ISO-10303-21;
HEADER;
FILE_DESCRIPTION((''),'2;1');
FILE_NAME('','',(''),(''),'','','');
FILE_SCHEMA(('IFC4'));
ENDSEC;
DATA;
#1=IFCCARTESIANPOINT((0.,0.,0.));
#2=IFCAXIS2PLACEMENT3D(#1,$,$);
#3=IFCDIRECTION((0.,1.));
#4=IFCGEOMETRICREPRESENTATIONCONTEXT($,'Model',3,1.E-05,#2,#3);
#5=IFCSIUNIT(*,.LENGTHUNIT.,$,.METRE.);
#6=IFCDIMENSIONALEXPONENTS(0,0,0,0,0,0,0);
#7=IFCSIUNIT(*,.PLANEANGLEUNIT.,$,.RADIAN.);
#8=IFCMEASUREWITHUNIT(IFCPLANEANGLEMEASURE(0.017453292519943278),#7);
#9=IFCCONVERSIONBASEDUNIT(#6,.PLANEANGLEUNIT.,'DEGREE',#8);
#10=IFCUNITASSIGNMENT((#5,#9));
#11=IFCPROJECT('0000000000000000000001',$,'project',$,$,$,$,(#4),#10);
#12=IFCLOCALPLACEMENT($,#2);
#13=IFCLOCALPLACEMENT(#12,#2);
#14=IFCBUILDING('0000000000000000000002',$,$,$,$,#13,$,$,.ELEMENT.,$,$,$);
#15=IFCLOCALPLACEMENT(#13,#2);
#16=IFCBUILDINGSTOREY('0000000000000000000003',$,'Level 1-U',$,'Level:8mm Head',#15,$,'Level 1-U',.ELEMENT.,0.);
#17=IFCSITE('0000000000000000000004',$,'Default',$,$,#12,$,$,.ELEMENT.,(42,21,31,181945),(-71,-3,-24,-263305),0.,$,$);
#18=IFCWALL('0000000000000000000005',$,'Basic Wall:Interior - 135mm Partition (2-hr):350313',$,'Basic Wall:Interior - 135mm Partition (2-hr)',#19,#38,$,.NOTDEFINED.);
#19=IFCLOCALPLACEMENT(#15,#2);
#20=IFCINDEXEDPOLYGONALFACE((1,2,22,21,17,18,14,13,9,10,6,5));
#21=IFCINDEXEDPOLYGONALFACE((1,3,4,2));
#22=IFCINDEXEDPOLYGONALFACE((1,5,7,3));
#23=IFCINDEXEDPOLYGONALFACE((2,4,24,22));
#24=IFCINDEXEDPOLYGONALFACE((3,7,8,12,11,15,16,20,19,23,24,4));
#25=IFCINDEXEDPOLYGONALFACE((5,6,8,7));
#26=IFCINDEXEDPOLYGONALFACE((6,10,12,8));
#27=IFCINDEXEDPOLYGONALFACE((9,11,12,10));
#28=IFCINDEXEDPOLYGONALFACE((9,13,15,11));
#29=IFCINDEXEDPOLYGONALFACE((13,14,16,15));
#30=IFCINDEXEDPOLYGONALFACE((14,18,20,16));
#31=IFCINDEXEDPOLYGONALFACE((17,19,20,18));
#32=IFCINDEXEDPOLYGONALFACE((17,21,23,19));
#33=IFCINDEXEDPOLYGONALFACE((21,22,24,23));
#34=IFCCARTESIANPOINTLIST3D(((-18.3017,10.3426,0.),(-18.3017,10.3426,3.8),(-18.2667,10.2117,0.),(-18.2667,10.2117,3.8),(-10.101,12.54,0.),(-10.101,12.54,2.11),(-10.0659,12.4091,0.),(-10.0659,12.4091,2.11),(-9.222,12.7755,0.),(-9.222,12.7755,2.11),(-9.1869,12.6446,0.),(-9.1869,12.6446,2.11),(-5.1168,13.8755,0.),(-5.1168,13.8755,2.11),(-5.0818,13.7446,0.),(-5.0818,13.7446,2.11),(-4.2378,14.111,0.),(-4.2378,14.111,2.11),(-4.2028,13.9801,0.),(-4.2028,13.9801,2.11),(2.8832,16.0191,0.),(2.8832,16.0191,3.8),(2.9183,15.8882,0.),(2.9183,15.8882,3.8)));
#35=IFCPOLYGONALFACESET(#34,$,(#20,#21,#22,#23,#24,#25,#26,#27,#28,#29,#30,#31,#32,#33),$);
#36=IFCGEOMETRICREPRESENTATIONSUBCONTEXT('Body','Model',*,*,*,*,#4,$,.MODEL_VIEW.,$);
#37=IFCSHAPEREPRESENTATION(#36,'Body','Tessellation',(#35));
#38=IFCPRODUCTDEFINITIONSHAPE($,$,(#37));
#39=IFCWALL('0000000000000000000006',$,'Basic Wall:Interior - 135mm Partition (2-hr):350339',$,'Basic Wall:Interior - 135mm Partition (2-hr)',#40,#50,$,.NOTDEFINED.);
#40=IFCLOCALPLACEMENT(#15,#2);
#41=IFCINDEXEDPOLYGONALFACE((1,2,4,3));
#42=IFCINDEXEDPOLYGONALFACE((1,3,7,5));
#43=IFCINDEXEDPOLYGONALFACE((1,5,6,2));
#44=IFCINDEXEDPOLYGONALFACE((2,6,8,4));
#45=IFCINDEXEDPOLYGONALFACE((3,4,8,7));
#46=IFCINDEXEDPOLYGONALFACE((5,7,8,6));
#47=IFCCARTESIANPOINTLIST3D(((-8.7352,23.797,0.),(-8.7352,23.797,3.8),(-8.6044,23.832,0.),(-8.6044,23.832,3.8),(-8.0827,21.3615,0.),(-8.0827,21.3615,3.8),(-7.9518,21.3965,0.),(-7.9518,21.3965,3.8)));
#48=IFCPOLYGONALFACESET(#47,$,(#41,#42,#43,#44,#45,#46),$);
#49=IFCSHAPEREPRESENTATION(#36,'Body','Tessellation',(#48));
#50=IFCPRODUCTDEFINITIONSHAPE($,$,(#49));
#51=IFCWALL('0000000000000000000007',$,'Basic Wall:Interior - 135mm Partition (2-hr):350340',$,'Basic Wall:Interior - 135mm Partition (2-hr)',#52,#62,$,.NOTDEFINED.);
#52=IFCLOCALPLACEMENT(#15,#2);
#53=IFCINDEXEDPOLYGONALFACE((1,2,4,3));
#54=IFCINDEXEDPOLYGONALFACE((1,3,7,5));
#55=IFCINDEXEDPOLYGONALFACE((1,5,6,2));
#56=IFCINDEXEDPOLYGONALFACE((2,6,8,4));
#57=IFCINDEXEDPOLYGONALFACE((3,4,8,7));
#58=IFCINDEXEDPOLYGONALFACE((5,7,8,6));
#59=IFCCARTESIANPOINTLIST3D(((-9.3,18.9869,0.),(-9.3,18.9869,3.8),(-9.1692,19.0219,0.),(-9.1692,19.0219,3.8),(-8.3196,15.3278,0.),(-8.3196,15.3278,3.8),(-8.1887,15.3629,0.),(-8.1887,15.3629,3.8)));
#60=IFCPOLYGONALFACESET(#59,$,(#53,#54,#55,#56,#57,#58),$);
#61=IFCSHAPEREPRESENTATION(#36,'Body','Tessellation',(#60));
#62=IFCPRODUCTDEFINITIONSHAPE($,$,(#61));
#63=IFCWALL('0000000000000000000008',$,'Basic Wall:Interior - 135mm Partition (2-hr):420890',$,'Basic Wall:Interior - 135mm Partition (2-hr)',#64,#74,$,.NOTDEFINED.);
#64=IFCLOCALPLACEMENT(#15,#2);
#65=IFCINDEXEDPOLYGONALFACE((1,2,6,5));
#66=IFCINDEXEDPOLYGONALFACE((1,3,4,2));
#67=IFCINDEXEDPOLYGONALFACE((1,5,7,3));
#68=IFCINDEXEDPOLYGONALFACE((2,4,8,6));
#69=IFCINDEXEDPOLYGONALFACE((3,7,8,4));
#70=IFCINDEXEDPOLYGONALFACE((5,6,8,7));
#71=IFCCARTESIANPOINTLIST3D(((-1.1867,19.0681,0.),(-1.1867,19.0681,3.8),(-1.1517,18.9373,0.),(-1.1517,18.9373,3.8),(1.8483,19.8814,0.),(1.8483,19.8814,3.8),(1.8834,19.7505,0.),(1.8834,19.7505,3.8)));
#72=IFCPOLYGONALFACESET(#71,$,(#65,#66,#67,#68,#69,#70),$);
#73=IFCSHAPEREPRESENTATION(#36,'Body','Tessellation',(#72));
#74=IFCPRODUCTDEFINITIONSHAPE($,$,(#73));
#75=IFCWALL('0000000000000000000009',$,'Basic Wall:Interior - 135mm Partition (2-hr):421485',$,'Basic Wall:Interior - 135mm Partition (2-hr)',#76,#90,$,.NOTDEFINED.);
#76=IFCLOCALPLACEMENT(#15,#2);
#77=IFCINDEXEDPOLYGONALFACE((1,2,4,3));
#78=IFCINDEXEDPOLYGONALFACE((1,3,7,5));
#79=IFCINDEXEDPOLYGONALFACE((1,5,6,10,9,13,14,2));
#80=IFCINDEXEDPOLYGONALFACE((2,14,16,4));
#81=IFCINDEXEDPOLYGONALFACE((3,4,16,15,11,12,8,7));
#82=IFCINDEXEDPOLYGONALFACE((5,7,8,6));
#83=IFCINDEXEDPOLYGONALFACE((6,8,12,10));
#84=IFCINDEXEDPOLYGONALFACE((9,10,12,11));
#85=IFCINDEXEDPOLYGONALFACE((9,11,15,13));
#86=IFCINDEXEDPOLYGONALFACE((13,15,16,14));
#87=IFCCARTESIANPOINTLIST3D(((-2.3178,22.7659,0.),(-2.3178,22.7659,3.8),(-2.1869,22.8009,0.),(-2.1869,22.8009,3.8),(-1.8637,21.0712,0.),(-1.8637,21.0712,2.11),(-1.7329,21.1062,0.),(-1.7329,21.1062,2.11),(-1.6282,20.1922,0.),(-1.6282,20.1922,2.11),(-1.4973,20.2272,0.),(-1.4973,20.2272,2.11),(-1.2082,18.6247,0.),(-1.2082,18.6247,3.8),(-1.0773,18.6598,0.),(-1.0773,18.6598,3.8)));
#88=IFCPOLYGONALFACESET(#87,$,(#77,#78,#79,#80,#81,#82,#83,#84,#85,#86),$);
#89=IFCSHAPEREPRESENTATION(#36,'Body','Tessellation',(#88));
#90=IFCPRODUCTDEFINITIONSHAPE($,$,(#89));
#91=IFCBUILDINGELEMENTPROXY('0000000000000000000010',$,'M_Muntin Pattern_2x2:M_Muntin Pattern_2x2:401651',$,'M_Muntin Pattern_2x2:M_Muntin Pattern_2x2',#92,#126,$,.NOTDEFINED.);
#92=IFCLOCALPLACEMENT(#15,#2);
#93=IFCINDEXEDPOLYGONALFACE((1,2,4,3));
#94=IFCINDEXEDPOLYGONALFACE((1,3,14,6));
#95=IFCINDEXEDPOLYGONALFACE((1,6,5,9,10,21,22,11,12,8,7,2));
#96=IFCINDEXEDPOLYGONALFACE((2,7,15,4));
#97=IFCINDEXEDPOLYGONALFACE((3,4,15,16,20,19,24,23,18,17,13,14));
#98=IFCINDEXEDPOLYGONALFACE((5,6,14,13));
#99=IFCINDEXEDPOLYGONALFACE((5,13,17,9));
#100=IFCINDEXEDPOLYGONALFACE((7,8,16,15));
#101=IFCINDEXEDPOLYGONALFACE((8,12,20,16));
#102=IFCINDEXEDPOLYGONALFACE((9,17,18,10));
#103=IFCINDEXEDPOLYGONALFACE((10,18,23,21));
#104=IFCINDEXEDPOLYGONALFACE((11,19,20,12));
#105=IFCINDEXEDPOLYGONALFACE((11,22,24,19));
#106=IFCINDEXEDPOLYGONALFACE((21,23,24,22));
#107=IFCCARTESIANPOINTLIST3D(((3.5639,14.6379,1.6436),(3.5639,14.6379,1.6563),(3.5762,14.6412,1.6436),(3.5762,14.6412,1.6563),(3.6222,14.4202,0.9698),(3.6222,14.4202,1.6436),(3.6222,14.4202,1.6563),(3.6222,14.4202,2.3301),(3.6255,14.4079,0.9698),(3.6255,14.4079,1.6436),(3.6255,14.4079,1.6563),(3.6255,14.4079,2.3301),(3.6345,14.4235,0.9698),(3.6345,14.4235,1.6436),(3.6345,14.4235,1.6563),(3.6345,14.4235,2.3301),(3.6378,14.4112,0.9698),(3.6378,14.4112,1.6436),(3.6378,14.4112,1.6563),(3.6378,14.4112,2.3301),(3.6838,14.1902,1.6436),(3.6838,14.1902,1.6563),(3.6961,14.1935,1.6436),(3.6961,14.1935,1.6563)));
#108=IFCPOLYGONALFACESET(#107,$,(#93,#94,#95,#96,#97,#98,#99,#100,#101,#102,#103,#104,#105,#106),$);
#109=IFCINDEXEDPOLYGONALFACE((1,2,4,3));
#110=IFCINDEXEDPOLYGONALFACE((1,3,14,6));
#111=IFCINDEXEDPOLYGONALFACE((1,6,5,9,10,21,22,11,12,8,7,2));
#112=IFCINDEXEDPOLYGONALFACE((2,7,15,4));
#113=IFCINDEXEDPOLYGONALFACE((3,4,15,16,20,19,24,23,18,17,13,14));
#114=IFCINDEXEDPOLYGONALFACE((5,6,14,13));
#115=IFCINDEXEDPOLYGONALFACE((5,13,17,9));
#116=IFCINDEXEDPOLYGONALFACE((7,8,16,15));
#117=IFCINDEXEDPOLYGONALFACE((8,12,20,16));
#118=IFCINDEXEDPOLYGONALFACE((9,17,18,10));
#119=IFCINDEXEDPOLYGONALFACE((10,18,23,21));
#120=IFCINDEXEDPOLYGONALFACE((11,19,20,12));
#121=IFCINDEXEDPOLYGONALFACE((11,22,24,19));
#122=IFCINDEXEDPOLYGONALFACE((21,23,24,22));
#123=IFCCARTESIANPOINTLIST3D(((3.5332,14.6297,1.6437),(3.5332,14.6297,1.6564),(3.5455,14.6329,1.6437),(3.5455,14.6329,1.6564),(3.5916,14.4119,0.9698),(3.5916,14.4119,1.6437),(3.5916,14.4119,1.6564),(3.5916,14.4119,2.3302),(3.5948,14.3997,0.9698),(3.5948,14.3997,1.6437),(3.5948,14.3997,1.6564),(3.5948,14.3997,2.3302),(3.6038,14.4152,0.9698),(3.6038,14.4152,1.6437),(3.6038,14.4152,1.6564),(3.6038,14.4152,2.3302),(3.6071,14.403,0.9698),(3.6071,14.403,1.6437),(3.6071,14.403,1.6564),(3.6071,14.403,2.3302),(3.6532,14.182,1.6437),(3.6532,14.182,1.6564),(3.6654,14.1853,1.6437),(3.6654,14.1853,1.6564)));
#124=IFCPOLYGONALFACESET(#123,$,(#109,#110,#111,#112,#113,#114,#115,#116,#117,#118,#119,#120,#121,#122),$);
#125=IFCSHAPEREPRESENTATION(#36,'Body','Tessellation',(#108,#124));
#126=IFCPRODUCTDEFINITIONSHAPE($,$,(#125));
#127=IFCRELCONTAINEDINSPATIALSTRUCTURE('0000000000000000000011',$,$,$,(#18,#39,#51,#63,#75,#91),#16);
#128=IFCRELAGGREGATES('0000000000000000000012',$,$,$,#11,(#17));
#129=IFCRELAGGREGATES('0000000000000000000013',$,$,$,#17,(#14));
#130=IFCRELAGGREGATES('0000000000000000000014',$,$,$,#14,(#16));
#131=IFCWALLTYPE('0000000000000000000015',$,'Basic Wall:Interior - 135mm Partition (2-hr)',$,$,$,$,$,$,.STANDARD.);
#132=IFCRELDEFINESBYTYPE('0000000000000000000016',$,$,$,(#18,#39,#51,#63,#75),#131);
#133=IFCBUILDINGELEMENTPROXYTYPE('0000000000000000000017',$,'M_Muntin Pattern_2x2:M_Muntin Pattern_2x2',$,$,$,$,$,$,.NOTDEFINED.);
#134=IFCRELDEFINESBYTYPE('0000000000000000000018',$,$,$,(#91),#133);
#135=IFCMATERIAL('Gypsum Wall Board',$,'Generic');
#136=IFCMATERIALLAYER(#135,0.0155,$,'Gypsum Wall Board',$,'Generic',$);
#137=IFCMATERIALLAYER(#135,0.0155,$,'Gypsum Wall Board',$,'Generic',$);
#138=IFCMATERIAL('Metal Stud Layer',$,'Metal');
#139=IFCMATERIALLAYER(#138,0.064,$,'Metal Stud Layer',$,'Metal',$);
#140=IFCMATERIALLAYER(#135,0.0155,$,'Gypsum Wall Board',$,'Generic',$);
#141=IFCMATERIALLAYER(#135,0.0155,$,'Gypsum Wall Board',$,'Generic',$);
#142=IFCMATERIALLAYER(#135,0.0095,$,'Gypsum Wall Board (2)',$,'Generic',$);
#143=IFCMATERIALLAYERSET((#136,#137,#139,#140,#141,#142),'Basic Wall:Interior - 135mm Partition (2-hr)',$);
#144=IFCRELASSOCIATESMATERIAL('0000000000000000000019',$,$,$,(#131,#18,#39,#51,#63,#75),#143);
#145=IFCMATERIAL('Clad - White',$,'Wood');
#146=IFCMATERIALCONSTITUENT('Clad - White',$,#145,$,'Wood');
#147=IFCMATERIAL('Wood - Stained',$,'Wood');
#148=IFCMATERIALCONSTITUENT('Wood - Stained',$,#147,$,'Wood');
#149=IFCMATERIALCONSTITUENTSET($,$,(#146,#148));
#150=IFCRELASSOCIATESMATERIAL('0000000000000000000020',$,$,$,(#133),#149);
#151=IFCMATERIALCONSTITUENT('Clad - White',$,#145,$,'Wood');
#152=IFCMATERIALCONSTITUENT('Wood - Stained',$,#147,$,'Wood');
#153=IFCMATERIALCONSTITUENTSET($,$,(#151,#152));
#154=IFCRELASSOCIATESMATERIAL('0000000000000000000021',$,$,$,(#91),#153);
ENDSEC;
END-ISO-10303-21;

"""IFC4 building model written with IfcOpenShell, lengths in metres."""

from ifc_helpers import new_model, entity, si_unit, converted_unit, direction, frame, frame_2d, origin, place, context, subcontext, project, spatial, polyline, rectangle, outline, extrude, source, transform, mapped, material, layer, layer_set, layer_usage, constituent, constituent_set, type_object, type_shapes, element, save


model = new_model("IFC4")

# Units and contexts
model_context = context("Model", 3, precision=1e-05, world=origin(), true_north=direction((0.0, 1.0)))
body_context = subcontext(model_context, "Body", "Model", "MODEL_VIEW")
ifc_project = project(units=[si_unit("LENGTHUNIT", "METRE"), converted_unit("PLANEANGLEUNIT", "DEGREE", entity("IfcPlaneAngleMeasure", 0.017453292519943278), si_unit("PLANEANGLEUNIT", "RADIAN"), dimensions=[0, 0, 0, 0, 0, 0, 0])], contexts=[model_context])

# Site, building, storey
site_placement = place(None, origin())
site = spatial("IfcSite", under=ifc_project, at=site_placement, Name="Default", CompositionType="ELEMENT", RefLatitude=(42, 21, 31, 181945), RefLongitude=(-71, -3, -24, -263305), RefElevation=0.0)
building_placement = place(site_placement, origin())
building = spatial("IfcBuilding", under=site, at=building_placement, CompositionType="ELEMENT")
storey_placement = place(building_placement, origin())
storey = spatial("IfcBuildingStorey", under=building, at=storey_placement, Name="Level 1-U", ObjectType="Level:8mm Head", LongName="Level 1-U", CompositionType="ELEMENT", Elevation=0.0)

# Shared definitions
ifc_material_1 = material(Name="Gypsum Wall Board", Category="Generic")
ifc_layer_1 = layer(ifc_material_1, 0.0155, Name="Gypsum Wall Board", Category="Generic")
ifc_layer_2 = layer(ifc_material_1, 0.0155, Name="Gypsum Wall Board", Category="Generic")
ifc_material_2 = material(Name="Metal Stud Layer", Category="Metal")
ifc_layer_3 = layer(ifc_material_2, 0.064, Name="Metal Stud Layer", Category="Metal")
ifc_layer_4 = layer(ifc_material_1, 0.0155, Name="Gypsum Wall Board", Category="Generic")
ifc_layer_5 = layer(ifc_material_1, 0.0155, Name="Gypsum Wall Board", Category="Generic")
ifc_layer_6 = layer(ifc_material_1, 0.0095, Name="Gypsum Wall Board (2)", Category="Generic")
ifc_layer_set_1 = layer_set([ifc_layer_1, ifc_layer_2, ifc_layer_3, ifc_layer_4, ifc_layer_5, ifc_layer_6], Name="Basic Wall:Interior - 135mm Partition (2-hr)")
ifc_layer_usage_1 = layer_usage(ifc_layer_set_1, "AXIS2", "NEGATIVE", 0.0677)
wall_type_1 = type_object("IfcWallType", Name="Basic Wall:Interior - 135mm Partition (2-hr)", PredefinedType="STANDARD", material=ifc_layer_set_1)

# Wall, openings
wall_1_placement = place(storey_placement, frame((2.9007, 15.9537, 0.0), z_axis=(0.0, 0.0, 1.0), x_axis=(-0.965926, -0.258819, 0.0)))
wall_1 = element("IfcWall", 1, at=wall_1_placement, inside=storey, type_object=wall_type_1, material=ifc_layer_usage_1, Name="Basic Wall:Interior - 135mm Partition (2-hr):350313", ObjectType="Basic Wall:Interior - 135mm Partition (2-hr)", PredefinedType="NOTDEFINED", context=body_context, shape_type="SweptSolid", body=[
    extrude(rectangle(XDim=21.9323, YDim=0.1355, at=frame_2d((10.9661, 0.0), x_axis=(1.0, 0.0))), origin(), (0.0, 0.0, 1.0), 3.8),
])
opening_1_placement = place(wall_1_placement, frame((7.3722, -0.0678, 0.0)))
element("IfcOpeningElement", 2, at=opening_1_placement, cuts=wall_1, PredefinedType="OPENING", context=body_context, shape_type="SweptSolid", body=[
    extrude(rectangle(XDim=2.11, YDim=0.91, at=frame_2d((1.055, 0.455), x_axis=(1.0, 0.0))), frame((0.0, 0.0, 0.0), z_axis=(0.0, 1.0, 0.0), x_axis=(0.0, 0.0, 1.0)), (0.0, 0.0, 1.0), 0.1355),
])
opening_2_placement = place(wall_1_placement, frame((12.5323, -0.0678, 0.0)))
element("IfcOpeningElement", 3, at=opening_2_placement, cuts=wall_1, PredefinedType="OPENING", context=body_context, shape_type="SweptSolid", body=[
    extrude(rectangle(XDim=2.11, YDim=0.91, at=frame_2d((1.055, 0.455), x_axis=(1.0, 0.0))), frame((0.0, 0.0, 0.0), z_axis=(0.0, 1.0, 0.0), x_axis=(0.0, 0.0, 1.0)), (0.0, 0.0, 1.0), 0.1355),
])

# Walls
wall_2_placement = place(storey_placement, frame((-8.0172, 21.379, 0.0), z_axis=(0.0, 0.0, 1.0), x_axis=(-0.258819, 0.965926, 0.0)))
element("IfcWall", 4, at=wall_2_placement, inside=storey, type_object=wall_type_1, material=ifc_layer_usage_1, Name="Basic Wall:Interior - 135mm Partition (2-hr):350339", ObjectType="Basic Wall:Interior - 135mm Partition (2-hr)", PredefinedType="NOTDEFINED", context=body_context, shape_type="SweptSolid", body=[
    extrude(rectangle(XDim=2.5214, YDim=0.1355, at=frame_2d((1.2607, 0.0), x_axis=(-1.0, 0.0))), origin(), (0.0, 0.0, 1.0), 3.8),
])
wall_3_placement = place(storey_placement, frame((-8.2542, 15.3453, 0.0), z_axis=(0.0, 0.0, 1.0), x_axis=(-0.258819, 0.965926, 0.0)))
element("IfcWall", 5, at=wall_3_placement, inside=storey, type_object=wall_type_1, material=ifc_layer_usage_1, Name="Basic Wall:Interior - 135mm Partition (2-hr):350340", ObjectType="Basic Wall:Interior - 135mm Partition (2-hr)", PredefinedType="NOTDEFINED", context=body_context, shape_type="SweptSolid", body=[
    extrude(rectangle(XDim=3.7881, YDim=0.1355, at=frame_2d((1.8941, 0.0), x_axis=(-1.0, 0.0))), origin(), (0.0, 0.0, 1.0), 3.8),
])
wall_4_placement = place(storey_placement, frame((-1.1692, 19.0027, 0.0), z_axis=(0.0, 0.0, 1.0), x_axis=(0.965926, 0.258819, 0.0)))
element("IfcWall", 6, at=wall_4_placement, inside=storey, type_object=wall_type_1, material=ifc_layer_usage_1, Name="Basic Wall:Interior - 135mm Partition (2-hr):420890", ObjectType="Basic Wall:Interior - 135mm Partition (2-hr)", PredefinedType="NOTDEFINED", context=body_context, shape_type="SweptSolid", body=[
    extrude(rectangle(XDim=3.1421, YDim=0.1355, at=frame_2d((1.5711, 0.0), x_axis=(-1.0, 0.0))), origin(), (0.0, 0.0, 1.0), 3.8),
])

# Wall, opening
wall_5_placement = place(storey_placement, frame((-1.1428, 18.6422, 0.0), z_axis=(0.0, 0.0, 1.0), x_axis=(-0.258819, 0.965926, 0.0)))
wall_5 = element("IfcWall", 7, at=wall_5_placement, inside=storey, type_object=wall_type_1, material=ifc_layer_usage_1, Name="Basic Wall:Interior - 135mm Partition (2-hr):421485", ObjectType="Basic Wall:Interior - 135mm Partition (2-hr)", PredefinedType="NOTDEFINED", context=body_context, shape_type="SweptSolid", body=[
    extrude(rectangle(XDim=4.2873, YDim=0.1355, at=frame_2d((2.1436, 0.0), x_axis=(-1.0, 0.0))), origin(), (0.0, 0.0, 1.0), 3.8),
])
opening_3_placement = place(wall_5_placement, frame((1.6228, -0.0678, 0.0)))
element("IfcOpeningElement", 8, at=opening_3_placement, cuts=wall_5, PredefinedType="OPENING", context=body_context, shape_type="SweptSolid", body=[
    extrude(rectangle(XDim=2.11, YDim=0.91, at=frame_2d((1.055, 0.455), x_axis=(1.0, 0.0))), frame((0.0, 0.0, 0.0), z_axis=(0.0, 1.0, 0.0), x_axis=(0.0, 0.0, 1.0)), (0.0, 0.0, 1.0), 0.1355),
])

# Building element proxy
ifc_material_3 = material(Name="Clad - White", Category="Wood")
ifc_constituent_1 = constituent(ifc_material_3, Name="Clad - White", Category="Wood")
ifc_material_4 = material(Name="Wood - Stained", Category="Wood")
ifc_constituent_2 = constituent(ifc_material_4, Name="Wood - Stained", Category="Wood")
ifc_constituent_set_1 = constituent_set(constituents=[ifc_constituent_1, ifc_constituent_2])
ifc_constituent_3 = constituent(ifc_material_3, Name="Clad - White", Category="Wood")
ifc_constituent_4 = constituent(ifc_material_4, Name="Wood - Stained", Category="Wood")
ifc_constituent_set_2 = constituent_set(constituents=[ifc_constituent_3, ifc_constituent_4])
building_element_proxy_type_1 = type_object("IfcBuildingElementProxyType", Name="M_Muntin Pattern_2x2:M_Muntin Pattern_2x2", PredefinedType="NOTDEFINED", material=ifc_constituent_set_2)
shared_shape_1 = source(origin(), body_context, "Body", "SweptSolid", [
    extrude(outline(polyline([(0.0064, -0.0064), (0.6801, -0.0064), (0.6801, 0.0063), (0.0064, 0.0063), (0.0064, 0.2317), (-0.0063, 0.2317), (-0.0063, 0.0063), (-0.6802, 0.0063), (-0.6802, -0.0064), (-0.0063, -0.0064), (-0.0063, -0.2317), (0.0064, -0.2317), (0.0064, -0.0064)])), frame((0.0, 0.0095, 0.6801), z_axis=(0.0, 1.0, 0.0), x_axis=(0.0, 0.0, 1.0)), (0.0, 0.0, 1.0), 0.0127),
    extrude(outline(polyline([(0.0064, -0.0064), (0.6802, -0.0064), (0.6802, 0.0063), (0.0064, 0.0063), (0.0064, 0.2317), (-0.0063, 0.2317), (-0.0063, 0.0063), (-0.6802, 0.0063), (-0.6802, -0.0064), (-0.0063, -0.0064), (-0.0063, -0.2317), (0.0064, -0.2317), (0.0064, -0.0064)])), frame((0.0, -0.0222, 0.6802), z_axis=(0.0, 1.0, 0.0), x_axis=(0.0, 0.0, 1.0)), (0.0, 0.0, 1.0), 0.0127),
])
type_shapes(building_element_proxy_type_1, [shared_shape_1])
proxy_1_placement = place(storey_placement, frame((3.6147, 14.4116, 0.9698), z_axis=(0.0, 0.0, 1.0), x_axis=(0.258819, -0.965926, 0.0)))
element("IfcBuildingElementProxy", 9, at=proxy_1_placement, inside=storey, type_object=building_element_proxy_type_1, material=ifc_constituent_set_1, Name="M_Muntin Pattern_2x2:M_Muntin Pattern_2x2:401651", ObjectType="M_Muntin Pattern_2x2:M_Muntin Pattern_2x2", PredefinedType="NOTDEFINED", context=body_context, shape_type="MappedRepresentation", body=[
    mapped(shared_shape_1, transform((0.0, 0.0, 0.0), scale=1.0)),
])

save(model, "model.ifc")
